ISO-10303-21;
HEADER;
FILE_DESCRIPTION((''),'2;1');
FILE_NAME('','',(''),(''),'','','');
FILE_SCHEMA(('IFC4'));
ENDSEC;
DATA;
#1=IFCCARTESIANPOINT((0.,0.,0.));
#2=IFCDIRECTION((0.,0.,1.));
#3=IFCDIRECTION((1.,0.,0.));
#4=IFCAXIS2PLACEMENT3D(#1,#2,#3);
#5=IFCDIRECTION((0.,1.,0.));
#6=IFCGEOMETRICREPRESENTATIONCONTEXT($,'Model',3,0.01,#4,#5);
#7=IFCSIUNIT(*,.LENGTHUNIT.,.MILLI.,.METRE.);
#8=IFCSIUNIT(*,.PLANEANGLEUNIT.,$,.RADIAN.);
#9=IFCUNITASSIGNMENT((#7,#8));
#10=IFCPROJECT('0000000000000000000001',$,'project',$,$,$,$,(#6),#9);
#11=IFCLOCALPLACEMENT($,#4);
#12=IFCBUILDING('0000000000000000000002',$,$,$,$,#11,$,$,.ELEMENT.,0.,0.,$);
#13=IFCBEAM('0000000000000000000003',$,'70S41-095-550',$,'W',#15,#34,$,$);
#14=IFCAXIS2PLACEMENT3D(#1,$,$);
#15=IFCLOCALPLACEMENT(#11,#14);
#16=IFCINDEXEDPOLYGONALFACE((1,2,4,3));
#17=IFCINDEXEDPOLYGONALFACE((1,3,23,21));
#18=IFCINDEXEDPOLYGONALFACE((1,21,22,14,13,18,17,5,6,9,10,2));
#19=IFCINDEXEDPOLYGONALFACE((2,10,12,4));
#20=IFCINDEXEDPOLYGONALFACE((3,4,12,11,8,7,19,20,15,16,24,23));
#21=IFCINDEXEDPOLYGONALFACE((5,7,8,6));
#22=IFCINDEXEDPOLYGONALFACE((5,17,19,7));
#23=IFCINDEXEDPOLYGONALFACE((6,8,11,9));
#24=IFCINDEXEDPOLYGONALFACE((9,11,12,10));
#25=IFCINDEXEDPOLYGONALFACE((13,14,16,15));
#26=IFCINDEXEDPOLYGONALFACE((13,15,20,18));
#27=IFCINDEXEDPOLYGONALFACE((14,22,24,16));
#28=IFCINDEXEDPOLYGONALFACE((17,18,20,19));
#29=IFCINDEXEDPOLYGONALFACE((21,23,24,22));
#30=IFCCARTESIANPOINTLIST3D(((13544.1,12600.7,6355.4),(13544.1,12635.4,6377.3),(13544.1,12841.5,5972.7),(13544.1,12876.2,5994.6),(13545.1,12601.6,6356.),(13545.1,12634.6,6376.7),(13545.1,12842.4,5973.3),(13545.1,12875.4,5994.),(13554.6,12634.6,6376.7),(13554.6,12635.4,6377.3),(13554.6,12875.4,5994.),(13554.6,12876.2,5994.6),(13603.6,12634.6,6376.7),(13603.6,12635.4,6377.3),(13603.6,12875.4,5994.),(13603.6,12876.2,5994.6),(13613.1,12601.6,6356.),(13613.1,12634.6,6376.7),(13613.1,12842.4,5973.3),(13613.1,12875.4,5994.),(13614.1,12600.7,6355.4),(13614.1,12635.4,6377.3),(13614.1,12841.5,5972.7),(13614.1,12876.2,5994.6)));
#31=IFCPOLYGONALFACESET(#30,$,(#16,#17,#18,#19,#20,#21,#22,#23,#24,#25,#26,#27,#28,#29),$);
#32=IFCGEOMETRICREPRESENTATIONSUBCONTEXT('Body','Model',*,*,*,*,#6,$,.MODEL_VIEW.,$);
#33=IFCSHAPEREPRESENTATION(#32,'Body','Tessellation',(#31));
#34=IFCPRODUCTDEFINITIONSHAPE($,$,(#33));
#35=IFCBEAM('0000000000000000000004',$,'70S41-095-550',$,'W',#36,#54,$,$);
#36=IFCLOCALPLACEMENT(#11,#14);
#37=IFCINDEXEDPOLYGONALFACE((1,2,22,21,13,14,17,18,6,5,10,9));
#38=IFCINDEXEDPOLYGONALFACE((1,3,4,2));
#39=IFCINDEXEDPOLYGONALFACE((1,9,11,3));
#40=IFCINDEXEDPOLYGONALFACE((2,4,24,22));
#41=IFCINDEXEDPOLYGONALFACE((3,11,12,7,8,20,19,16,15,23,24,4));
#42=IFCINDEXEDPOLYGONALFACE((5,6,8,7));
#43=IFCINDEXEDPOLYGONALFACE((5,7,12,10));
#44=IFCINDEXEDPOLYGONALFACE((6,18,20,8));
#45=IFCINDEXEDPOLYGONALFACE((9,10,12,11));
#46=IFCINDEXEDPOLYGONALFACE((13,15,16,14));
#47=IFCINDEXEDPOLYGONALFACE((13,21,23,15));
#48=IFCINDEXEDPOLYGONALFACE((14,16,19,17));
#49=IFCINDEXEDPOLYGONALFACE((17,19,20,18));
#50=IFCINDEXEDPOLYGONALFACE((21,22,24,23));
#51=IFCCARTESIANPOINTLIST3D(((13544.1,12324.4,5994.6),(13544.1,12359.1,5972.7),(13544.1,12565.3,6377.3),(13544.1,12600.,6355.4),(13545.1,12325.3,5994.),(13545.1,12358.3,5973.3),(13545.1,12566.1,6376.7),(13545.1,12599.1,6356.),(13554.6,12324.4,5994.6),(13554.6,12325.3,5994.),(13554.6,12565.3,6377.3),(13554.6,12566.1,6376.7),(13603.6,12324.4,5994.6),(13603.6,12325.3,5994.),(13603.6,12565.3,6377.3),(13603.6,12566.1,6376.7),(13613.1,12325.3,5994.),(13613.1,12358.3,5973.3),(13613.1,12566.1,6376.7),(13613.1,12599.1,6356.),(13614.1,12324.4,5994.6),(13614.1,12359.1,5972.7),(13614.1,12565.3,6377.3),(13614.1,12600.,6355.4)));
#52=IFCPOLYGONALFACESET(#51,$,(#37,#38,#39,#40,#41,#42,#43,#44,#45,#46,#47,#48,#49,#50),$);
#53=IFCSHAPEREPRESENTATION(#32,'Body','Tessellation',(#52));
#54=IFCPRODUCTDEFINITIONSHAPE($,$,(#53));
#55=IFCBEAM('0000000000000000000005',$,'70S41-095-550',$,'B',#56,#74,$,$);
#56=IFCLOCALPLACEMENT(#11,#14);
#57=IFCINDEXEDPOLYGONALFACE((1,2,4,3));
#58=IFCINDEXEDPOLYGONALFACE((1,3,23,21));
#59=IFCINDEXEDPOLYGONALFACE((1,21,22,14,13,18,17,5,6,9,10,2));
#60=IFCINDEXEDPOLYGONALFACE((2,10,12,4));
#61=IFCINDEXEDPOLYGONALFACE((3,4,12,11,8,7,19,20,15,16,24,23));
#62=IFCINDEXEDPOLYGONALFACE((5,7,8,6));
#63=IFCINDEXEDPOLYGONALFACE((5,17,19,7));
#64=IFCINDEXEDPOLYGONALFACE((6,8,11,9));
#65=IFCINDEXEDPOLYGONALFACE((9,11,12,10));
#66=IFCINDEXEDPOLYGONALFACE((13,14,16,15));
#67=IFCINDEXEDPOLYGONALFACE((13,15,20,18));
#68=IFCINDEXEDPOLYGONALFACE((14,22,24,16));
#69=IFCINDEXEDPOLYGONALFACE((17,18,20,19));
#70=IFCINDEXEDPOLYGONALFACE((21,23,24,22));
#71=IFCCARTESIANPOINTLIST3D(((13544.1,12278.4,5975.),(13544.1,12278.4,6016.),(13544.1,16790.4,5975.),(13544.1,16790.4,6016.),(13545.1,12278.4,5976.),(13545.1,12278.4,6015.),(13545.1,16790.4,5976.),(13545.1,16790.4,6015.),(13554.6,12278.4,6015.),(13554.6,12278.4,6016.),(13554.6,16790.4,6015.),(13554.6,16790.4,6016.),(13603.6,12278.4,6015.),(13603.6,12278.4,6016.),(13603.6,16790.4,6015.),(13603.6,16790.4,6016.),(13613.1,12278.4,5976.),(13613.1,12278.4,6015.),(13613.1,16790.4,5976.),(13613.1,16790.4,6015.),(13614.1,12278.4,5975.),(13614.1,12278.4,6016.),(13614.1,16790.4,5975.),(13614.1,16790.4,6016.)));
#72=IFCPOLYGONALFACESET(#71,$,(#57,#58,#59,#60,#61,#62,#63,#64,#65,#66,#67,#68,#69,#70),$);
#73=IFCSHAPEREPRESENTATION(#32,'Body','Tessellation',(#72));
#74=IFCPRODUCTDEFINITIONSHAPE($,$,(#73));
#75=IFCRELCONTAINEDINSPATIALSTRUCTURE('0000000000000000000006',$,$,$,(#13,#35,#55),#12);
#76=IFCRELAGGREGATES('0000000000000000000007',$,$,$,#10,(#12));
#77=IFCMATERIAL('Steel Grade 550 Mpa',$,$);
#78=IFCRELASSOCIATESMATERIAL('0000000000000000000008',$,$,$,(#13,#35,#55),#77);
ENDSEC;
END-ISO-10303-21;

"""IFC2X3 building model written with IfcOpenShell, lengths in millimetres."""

from ifc_helpers import new_model, si_unit, direction, frame, origin, origin_with_axes, origin_2d_with_axis, place, context, subcontext, project, spatial, c_section, extrude, source, transform, mapped, material, element, save


model = new_model("IFC2X3")

# Units and contexts
model_context = context("Model", 3, precision=0.01, world=origin_with_axes(), true_north=direction((0.0, 1.0, 0.0)))
body_context = subcontext(model_context, "Body", "Model", "MODEL_VIEW")
ifc_project = project(units=[si_unit("LENGTHUNIT", "METRE", prefix="MILLI"), si_unit("PLANEANGLEUNIT", "RADIAN")], contexts=[model_context])

# Building
building_placement = place(None, origin_with_axes())
building = spatial("IfcBuilding", under=ifc_project, at=building_placement, CompositionType="ELEMENT", ElevationOfRefHeight=0.0, ElevationOfTerrain=0.0)

# Beams
ifc_material = material(Name="Steel Grade 550 Mpa")
shared_shape_1 = source(origin(), body_context, "Body", "SweptSolid", [
    extrude(c_section(Depth=70.0, Width=41.0, WallThickness=1.0, Girth=10.5, at=origin_2d_with_axis()), origin_with_axes(), (0.0, 0.0, 1.0), 452.2),
])
beam_1_placement = place(None, frame((13579.1, 12618.1, 6366.3), z_axis=(0.0, 0.532581, -0.846379), x_axis=(0.0, 0.846379, 0.532581)))
element("IfcBeam", 1, at=beam_1_placement, inside=building, material=ifc_material, Name="70S41-095-550", ObjectType="W", context=body_context, shape_type="MappedRepresentation", body=[
    mapped(shared_shape_1, transform((0.0, 0.0, 0.0), scale=1.0)),
])
shared_shape_2 = source(origin(), body_context, "Body", "SweptSolid", [
    extrude(c_section(Depth=70.0, Width=41.0, WallThickness=1.0, Girth=10.5, at=origin_2d_with_axis()), origin_with_axes(), (0.0, 0.0, 1.0), 452.2),
])
beam_2_placement = place(None, frame((13579.1, 12341.8, 5983.7), z_axis=(0.0, 0.532581, 0.846379), x_axis=(0.0, -0.846379, 0.532581)))
element("IfcBeam", 2, at=beam_2_placement, inside=building, material=ifc_material, Name="70S41-095-550", ObjectType="W", context=body_context, shape_type="MappedRepresentation", body=[
    mapped(shared_shape_2, transform((0.0, 0.0, 0.0), scale=1.0)),
])
shared_shape_3 = source(origin(), body_context, "Body", "SweptSolid", [
    extrude(c_section(Depth=70.0, Width=41.0, WallThickness=1.0, Girth=10.5, at=origin_2d_with_axis()), origin_with_axes(), (0.0, 0.0, 1.0), 4512.0),
])
beam_3_placement = place(None, frame((13579.1, 12278.4, 5995.5), z_axis=(0.0, 1.0, 0.0), x_axis=(0.0, 0.0, 1.0)))
element("IfcBeam", 3, at=beam_3_placement, inside=building, material=ifc_material, Name="70S41-095-550", ObjectType="B", context=body_context, shape_type="MappedRepresentation", body=[
    mapped(shared_shape_3, transform((0.0, 0.0, 0.0), scale=1.0)),
])

save(model, "model.ifc")
